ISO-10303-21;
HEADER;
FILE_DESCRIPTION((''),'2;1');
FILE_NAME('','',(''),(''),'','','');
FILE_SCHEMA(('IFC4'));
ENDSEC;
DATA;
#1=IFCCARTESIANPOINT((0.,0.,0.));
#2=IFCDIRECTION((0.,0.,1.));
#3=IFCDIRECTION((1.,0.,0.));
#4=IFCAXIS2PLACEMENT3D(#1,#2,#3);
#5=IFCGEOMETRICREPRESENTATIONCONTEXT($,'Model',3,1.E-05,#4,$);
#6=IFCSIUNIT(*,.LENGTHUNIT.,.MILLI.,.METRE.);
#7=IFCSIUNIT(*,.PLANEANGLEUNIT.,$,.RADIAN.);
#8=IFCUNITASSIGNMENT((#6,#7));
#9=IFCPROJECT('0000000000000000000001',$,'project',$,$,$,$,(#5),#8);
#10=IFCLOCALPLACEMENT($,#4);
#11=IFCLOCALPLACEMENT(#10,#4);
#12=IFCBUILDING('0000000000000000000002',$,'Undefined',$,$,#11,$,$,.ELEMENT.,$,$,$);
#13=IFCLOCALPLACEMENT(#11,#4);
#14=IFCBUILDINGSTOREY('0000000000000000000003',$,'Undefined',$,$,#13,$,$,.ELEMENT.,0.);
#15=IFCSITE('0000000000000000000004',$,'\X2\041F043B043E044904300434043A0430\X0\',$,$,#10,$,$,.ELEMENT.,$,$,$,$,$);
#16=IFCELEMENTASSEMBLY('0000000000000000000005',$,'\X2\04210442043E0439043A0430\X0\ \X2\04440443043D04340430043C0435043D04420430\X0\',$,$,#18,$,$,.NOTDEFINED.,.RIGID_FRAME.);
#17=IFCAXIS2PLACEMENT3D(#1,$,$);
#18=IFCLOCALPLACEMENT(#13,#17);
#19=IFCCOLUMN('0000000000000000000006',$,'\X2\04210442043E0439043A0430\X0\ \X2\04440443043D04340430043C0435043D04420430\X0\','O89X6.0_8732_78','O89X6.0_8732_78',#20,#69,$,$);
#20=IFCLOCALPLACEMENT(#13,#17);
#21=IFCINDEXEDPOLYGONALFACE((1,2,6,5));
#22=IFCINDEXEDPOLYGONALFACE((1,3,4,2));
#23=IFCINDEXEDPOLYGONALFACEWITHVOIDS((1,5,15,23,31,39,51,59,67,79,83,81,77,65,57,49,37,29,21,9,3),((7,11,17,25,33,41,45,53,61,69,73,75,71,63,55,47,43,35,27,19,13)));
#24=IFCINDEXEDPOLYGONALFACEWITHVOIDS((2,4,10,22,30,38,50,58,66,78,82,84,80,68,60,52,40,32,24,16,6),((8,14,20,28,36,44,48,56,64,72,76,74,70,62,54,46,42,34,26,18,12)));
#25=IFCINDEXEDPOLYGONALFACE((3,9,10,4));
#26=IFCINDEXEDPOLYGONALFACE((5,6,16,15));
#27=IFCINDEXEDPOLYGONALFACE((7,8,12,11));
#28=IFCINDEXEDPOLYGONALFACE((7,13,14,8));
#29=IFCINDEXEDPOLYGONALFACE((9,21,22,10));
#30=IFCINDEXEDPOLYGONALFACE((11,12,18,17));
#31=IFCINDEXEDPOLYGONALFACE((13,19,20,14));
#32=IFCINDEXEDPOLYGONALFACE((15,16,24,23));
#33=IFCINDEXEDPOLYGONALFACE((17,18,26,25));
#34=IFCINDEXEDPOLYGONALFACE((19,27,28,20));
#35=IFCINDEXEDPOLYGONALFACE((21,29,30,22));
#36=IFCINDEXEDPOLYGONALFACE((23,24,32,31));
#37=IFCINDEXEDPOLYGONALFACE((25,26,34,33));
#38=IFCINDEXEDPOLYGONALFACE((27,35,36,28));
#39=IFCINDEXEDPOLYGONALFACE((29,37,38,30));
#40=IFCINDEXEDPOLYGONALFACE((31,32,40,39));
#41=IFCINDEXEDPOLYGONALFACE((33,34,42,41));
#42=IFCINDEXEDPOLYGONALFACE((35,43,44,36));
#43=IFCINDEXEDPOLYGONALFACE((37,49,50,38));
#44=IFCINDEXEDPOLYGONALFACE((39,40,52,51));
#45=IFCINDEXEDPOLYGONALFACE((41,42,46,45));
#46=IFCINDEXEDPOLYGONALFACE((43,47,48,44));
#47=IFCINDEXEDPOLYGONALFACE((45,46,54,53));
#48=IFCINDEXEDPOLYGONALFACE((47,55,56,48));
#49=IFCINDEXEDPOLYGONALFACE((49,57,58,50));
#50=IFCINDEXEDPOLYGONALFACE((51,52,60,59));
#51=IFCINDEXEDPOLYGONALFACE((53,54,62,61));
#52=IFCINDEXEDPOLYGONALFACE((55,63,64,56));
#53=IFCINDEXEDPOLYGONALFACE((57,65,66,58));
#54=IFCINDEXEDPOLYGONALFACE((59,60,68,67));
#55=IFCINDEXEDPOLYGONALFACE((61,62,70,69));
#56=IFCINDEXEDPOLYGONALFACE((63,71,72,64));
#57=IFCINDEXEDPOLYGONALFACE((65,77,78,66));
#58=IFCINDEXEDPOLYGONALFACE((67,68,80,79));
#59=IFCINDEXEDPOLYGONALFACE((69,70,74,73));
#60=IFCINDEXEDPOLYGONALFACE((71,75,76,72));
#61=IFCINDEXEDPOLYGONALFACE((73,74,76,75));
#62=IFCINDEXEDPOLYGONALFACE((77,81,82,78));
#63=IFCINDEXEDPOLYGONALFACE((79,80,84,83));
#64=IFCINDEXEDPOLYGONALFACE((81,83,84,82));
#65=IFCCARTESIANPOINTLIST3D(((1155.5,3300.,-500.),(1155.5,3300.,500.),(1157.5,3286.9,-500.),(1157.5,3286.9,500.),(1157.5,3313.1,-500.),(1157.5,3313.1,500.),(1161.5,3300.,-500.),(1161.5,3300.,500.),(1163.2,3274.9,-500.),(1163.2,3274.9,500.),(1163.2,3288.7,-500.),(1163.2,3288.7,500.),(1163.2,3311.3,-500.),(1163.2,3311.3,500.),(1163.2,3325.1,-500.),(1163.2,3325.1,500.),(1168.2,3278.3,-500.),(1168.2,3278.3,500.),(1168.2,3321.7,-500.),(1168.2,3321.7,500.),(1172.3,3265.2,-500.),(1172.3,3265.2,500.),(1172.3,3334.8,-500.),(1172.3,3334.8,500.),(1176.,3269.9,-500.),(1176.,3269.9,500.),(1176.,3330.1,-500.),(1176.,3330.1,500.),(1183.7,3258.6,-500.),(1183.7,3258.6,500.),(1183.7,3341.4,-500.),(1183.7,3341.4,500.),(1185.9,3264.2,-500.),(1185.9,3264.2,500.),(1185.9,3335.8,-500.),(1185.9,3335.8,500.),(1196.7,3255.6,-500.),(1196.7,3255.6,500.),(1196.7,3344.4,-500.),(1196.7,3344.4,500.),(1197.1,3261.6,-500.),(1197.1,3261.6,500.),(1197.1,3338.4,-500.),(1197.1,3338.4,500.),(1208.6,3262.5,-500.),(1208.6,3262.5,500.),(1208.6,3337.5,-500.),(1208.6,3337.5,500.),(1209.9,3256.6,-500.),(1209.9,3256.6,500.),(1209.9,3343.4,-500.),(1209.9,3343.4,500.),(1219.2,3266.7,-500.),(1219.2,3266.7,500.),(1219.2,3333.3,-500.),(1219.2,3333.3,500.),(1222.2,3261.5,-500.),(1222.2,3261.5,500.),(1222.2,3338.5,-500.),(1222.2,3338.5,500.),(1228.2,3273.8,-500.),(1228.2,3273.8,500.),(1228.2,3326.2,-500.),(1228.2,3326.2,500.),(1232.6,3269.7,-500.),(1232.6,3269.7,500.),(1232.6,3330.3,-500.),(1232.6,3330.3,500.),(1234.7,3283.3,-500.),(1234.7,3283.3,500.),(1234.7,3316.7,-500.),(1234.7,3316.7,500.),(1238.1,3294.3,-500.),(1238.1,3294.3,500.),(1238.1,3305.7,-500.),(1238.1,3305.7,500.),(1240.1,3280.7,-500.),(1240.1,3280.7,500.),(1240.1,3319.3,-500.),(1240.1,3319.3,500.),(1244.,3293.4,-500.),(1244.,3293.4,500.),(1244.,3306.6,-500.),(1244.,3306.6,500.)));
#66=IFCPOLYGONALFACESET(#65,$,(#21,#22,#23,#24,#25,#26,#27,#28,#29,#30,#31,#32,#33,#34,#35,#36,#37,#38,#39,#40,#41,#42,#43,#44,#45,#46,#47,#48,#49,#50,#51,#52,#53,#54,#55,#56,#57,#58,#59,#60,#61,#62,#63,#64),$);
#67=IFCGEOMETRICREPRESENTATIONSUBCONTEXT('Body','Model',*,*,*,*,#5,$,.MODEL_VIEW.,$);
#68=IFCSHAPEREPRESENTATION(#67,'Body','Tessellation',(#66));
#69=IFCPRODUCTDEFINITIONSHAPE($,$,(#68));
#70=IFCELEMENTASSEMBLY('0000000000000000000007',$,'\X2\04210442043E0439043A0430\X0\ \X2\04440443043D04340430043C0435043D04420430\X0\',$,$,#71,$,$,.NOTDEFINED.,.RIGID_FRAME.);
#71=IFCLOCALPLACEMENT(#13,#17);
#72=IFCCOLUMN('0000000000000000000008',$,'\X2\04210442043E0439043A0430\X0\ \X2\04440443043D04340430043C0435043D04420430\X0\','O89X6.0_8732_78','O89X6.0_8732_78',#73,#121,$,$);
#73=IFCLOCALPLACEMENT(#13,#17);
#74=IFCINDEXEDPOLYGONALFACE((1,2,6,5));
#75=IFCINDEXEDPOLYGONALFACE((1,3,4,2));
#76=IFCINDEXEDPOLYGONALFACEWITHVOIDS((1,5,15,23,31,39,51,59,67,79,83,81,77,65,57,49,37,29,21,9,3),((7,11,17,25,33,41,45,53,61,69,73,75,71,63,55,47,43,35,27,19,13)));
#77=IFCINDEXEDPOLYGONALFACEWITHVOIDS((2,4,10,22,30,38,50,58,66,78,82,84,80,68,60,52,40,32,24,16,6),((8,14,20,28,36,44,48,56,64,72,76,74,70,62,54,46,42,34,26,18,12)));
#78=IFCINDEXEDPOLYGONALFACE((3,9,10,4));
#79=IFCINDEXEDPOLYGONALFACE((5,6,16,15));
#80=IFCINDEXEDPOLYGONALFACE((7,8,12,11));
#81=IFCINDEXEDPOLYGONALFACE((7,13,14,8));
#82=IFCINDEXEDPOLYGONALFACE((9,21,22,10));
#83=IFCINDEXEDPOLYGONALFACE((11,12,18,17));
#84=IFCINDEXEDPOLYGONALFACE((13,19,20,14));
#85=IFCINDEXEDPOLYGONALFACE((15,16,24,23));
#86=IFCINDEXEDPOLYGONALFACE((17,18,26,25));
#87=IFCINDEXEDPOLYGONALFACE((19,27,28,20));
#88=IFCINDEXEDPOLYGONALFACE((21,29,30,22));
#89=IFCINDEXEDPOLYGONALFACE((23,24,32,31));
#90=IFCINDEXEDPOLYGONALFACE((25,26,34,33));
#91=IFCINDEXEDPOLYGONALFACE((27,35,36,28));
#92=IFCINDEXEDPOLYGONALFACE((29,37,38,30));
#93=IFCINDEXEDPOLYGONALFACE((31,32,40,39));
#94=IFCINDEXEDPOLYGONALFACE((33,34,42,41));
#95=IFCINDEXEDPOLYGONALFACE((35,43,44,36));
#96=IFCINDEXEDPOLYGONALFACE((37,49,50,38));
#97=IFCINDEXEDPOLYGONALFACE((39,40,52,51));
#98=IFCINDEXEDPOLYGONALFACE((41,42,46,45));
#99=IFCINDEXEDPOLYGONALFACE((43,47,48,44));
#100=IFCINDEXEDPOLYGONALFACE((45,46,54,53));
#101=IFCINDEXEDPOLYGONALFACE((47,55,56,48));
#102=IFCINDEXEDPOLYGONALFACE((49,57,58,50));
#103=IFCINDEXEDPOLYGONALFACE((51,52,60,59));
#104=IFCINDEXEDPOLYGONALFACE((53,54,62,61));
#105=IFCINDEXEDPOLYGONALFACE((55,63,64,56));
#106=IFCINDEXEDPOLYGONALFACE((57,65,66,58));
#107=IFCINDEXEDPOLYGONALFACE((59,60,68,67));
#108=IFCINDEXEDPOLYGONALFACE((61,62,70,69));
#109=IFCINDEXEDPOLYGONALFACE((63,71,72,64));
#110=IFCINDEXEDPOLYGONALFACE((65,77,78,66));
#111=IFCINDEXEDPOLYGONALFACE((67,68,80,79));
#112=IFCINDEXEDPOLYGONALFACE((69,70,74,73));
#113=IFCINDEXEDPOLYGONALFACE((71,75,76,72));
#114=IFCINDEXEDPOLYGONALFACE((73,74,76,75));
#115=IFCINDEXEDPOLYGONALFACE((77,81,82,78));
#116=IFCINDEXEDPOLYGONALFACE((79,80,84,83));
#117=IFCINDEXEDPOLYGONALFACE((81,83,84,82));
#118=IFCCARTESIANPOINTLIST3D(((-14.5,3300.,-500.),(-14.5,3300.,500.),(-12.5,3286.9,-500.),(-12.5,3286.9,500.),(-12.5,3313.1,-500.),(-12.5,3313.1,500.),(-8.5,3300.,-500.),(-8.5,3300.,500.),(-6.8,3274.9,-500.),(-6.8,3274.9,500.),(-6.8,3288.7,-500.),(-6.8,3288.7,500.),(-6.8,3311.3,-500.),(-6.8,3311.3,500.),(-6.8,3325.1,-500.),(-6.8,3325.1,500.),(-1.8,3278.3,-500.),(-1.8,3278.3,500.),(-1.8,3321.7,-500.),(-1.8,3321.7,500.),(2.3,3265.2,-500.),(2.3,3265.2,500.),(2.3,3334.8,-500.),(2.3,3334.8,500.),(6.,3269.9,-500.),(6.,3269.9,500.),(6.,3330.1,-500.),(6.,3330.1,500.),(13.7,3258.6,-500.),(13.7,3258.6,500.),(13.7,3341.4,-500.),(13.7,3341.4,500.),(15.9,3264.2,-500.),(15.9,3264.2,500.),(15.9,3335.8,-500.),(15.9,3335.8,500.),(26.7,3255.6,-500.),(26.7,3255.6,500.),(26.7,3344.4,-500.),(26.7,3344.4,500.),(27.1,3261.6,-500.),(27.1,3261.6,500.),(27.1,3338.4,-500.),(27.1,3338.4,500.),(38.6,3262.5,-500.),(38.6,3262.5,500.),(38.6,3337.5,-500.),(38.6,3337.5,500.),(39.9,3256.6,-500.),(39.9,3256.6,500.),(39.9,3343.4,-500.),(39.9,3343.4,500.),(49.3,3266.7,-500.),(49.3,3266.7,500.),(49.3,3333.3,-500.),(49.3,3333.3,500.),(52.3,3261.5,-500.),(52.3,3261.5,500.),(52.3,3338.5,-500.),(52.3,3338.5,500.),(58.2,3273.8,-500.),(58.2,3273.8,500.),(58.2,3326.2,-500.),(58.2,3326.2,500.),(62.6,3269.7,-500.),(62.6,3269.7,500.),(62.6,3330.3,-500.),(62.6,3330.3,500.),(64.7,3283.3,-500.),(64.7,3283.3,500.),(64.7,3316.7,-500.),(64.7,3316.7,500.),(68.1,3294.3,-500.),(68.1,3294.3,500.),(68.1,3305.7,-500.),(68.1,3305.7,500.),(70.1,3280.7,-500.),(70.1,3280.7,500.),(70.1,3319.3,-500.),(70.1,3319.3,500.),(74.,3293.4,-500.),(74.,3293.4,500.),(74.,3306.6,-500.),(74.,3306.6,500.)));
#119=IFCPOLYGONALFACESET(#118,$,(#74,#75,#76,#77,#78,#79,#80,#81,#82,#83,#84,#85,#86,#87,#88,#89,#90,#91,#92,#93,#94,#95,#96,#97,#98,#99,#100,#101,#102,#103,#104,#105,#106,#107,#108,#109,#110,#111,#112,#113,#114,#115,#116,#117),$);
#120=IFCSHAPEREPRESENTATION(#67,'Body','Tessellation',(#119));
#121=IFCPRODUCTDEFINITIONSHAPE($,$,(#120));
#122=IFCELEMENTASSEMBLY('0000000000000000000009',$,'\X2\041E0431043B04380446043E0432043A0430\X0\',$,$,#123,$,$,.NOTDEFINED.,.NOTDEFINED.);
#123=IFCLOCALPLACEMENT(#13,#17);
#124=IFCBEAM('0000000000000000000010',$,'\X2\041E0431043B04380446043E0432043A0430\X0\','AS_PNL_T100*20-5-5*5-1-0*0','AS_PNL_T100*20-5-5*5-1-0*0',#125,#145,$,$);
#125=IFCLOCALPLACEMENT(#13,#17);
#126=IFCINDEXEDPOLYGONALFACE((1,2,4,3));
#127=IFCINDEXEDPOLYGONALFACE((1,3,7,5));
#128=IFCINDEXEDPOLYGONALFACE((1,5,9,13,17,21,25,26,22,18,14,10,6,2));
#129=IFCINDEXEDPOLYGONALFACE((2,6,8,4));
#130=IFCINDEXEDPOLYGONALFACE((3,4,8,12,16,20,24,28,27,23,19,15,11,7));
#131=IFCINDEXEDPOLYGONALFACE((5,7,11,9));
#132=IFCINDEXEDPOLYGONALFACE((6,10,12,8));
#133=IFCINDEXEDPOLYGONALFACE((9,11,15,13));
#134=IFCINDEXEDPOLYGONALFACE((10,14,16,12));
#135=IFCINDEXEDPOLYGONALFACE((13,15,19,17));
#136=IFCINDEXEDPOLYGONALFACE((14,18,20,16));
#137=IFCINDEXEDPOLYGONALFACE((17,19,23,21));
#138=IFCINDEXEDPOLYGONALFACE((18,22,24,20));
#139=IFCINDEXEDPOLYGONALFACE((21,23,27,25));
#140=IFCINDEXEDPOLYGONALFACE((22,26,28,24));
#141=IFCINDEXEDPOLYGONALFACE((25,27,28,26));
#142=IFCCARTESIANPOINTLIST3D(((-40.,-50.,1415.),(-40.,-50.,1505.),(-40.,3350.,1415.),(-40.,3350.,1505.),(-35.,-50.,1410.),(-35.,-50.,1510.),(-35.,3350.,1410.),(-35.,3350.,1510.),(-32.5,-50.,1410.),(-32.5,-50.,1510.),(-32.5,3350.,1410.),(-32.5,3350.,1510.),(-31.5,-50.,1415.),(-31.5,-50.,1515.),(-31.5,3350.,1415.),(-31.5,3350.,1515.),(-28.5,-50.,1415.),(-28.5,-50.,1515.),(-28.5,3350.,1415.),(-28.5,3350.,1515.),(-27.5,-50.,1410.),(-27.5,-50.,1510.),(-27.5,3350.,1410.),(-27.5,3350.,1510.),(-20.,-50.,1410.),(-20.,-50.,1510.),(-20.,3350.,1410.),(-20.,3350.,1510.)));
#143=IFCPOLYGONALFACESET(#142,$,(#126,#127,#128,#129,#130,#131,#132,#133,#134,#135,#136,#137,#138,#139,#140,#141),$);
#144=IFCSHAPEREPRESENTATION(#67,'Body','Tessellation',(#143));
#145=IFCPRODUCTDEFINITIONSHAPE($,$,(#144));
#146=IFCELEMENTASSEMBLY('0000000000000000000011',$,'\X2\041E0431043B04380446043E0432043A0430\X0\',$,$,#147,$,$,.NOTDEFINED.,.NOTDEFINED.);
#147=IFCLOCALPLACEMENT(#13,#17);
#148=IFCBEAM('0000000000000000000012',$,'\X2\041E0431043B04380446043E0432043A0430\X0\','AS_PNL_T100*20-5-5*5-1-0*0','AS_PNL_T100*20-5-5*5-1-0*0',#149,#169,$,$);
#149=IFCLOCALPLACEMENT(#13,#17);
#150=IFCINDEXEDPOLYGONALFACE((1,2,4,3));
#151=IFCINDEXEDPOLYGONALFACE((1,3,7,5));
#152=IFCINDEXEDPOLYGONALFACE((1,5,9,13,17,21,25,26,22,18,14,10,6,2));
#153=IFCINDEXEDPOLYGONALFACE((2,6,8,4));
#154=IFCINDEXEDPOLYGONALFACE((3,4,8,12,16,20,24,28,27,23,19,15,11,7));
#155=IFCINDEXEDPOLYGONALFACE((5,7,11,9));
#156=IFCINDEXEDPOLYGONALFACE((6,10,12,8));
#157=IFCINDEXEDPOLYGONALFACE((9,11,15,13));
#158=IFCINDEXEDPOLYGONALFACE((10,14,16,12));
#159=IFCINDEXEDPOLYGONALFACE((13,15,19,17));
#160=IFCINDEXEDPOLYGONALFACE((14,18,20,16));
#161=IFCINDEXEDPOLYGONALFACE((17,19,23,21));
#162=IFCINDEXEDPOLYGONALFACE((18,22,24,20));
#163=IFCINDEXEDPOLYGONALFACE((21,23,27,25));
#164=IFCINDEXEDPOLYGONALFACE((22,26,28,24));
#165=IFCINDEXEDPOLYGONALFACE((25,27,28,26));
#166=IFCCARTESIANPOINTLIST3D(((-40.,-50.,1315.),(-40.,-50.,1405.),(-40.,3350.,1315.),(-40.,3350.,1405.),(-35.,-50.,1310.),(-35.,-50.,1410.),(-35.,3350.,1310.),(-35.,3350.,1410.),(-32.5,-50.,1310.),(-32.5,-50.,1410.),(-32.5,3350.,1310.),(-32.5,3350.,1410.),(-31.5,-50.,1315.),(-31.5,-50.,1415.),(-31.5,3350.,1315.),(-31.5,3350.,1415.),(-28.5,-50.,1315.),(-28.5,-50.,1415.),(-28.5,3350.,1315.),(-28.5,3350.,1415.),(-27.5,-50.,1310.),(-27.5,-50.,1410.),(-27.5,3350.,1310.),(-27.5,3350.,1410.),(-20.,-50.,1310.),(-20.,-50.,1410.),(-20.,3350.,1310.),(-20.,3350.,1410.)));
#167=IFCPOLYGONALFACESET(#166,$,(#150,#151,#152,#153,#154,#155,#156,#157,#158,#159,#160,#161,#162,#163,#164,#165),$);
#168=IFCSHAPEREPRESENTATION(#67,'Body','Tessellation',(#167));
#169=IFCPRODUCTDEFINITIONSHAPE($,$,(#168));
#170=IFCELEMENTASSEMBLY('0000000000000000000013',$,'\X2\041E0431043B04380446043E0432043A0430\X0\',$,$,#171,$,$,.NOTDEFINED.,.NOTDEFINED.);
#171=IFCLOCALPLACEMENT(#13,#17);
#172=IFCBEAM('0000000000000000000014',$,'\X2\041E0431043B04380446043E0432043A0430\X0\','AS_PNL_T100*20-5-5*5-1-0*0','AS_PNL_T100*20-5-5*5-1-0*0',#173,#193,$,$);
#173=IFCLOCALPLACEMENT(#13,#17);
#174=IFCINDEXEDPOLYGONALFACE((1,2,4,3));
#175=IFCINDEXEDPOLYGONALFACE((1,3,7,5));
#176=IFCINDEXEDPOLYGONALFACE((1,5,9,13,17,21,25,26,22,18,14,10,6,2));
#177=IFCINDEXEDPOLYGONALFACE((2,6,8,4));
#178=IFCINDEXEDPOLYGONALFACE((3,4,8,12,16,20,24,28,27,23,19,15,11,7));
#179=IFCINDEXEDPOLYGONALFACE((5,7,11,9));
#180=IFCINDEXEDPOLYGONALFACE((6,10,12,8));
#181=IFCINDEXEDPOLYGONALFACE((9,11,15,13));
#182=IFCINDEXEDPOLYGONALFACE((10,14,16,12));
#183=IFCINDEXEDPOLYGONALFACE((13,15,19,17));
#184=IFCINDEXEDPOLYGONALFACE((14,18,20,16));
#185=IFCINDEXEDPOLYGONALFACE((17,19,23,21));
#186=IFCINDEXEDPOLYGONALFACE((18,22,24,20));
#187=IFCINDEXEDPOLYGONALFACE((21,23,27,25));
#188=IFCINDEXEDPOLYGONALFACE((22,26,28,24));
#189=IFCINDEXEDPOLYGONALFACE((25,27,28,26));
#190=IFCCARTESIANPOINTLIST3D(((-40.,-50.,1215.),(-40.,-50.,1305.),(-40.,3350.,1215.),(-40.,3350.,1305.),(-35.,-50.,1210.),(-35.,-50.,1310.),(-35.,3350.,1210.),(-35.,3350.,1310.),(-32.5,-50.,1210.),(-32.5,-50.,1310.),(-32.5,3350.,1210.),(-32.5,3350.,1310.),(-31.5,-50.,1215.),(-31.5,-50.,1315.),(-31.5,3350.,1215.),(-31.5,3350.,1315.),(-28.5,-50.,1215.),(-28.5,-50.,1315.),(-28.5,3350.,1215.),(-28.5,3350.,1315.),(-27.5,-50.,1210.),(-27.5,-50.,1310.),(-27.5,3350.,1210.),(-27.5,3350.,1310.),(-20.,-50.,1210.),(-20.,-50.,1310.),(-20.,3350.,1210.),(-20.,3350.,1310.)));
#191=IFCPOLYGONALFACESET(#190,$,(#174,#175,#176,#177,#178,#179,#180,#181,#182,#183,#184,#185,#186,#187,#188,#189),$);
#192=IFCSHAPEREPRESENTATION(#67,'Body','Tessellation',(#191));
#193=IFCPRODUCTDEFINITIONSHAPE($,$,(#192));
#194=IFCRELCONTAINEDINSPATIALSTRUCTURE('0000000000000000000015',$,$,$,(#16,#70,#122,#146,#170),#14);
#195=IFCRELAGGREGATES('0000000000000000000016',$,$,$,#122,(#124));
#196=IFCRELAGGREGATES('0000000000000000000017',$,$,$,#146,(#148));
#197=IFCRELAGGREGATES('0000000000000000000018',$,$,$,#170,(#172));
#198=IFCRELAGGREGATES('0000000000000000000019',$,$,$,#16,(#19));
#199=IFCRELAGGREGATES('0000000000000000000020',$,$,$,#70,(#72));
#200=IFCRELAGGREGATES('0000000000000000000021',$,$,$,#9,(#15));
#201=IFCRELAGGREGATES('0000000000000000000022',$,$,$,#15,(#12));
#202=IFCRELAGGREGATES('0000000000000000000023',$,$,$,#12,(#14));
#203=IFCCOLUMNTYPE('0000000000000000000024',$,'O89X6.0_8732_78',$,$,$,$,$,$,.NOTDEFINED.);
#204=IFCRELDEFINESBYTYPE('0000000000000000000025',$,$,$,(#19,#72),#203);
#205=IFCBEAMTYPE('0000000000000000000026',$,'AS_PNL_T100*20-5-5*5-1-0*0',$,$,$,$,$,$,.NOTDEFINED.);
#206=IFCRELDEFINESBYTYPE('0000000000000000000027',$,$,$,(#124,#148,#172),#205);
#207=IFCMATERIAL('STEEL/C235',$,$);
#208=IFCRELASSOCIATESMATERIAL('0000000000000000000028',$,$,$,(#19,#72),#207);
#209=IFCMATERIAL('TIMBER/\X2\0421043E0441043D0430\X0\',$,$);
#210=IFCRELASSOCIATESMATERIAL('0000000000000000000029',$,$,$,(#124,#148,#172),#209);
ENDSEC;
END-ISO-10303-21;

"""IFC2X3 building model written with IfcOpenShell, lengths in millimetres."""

from ifc_helpers import new_model, si_unit, frame, origin_with_axes, origin_2d_with_axis, place, context, subcontext, project, spatial, polyline, hollow_circle, outline, extrude, material, type_object, element, aggregate, save


model = new_model("IFC2X3")

# Units and contexts
model_context = context("Model", 3, precision=1e-05, world=origin_with_axes())
body_context = subcontext(model_context, "Body", "Model", "MODEL_VIEW")
ifc_project = project(units=[si_unit("LENGTHUNIT", "METRE", prefix="MILLI"), si_unit("PLANEANGLEUNIT", "RADIAN")], contexts=[model_context])

# Site, building, storey
site_placement = place(None, origin_with_axes())
site = spatial("IfcSite", under=ifc_project, at=site_placement, Name="Площадка", CompositionType="ELEMENT")
building_placement = place(site_placement, origin_with_axes())
building = spatial("IfcBuilding", under=site, at=building_placement, Name="Undefined", CompositionType="ELEMENT")
storey_placement = place(building_placement, origin_with_axes())
storey = spatial("IfcBuildingStorey", under=building, at=storey_placement, Name="Undefined", CompositionType="ELEMENT", Elevation=0.0)

# Element assemblies, columns
assembly_1_placement = place(storey_placement, origin_with_axes())
assembly_1 = element("IfcElementAssembly", 1, at=assembly_1_placement, inside=storey, Name="Стойка фундамента", AssemblyPlace="NOTDEFINED", PredefinedType="RIGID_FRAME")
ifc_material_1 = material(Name="STEEL/C235")
column_type = type_object("IfcColumnType", Name="O89X6.0_8732_78", PredefinedType="NOTDEFINED")
column_1_placement = place(assembly_1_placement, frame((1200.0, 3300.0, -500.0), z_axis=(0.0, 0.0, 1.0), x_axis=(0.0, 1.0, 0.0)))
column_1 = element("IfcColumn", 2, at=column_1_placement, type_object=column_type, material=ifc_material_1, Name="Стойка фундамента", Description="O89X6.0_8732_78", ObjectType="O89X6.0_8732_78", context=body_context, shape_type="SweptSolid", body=[
    extrude(hollow_circle(Radius=44.5, WallThickness=6.0, at=origin_2d_with_axis()), frame((0.0, 0.0, 1000.0), z_axis=(0.0, 0.0, -1.0), x_axis=(0.0, 1.0, 0.0)), (0.0, 0.0, 1.0), 1000.0),
])
assembly_2_placement = place(storey_placement, origin_with_axes())
assembly_2 = element("IfcElementAssembly", 3, at=assembly_2_placement, inside=storey, Name="Стойка фундамента", AssemblyPlace="NOTDEFINED", PredefinedType="RIGID_FRAME")
column_2_placement = place(assembly_2_placement, frame((30.0, 3300.0, -500.0), z_axis=(0.0, 0.0, 1.0), x_axis=(0.0, 1.0, 0.0)))
column_2 = element("IfcColumn", 4, at=column_2_placement, type_object=column_type, material=ifc_material_1, Name="Стойка фундамента", Description="O89X6.0_8732_78", ObjectType="O89X6.0_8732_78", context=body_context, shape_type="SweptSolid", body=[
    extrude(hollow_circle(Radius=44.5, WallThickness=6.0, at=origin_2d_with_axis()), frame((0.0, 0.0, 1000.0), z_axis=(0.0, 0.0, -1.0), x_axis=(0.0, 1.0, 0.0)), (0.0, 0.0, 1.0), 1000.0),
])

# Element assemblies, beams
assembly_3_placement = place(storey_placement, origin_with_axes())
assembly_3 = element("IfcElementAssembly", 5, at=assembly_3_placement, inside=storey, Name="Облицовка", AssemblyPlace="NOTDEFINED", PredefinedType="NOTDEFINED")
ifc_material_2 = material(Name="TIMBER/Сосна")
beam_type = type_object("IfcBeamType", Name="AS_PNL_T100*20-5-5*5-1-0*0", PredefinedType="NOTDEFINED")
beam_1_placement = place(assembly_3_placement, frame((-30.0, 3350.0, 1460.0), z_axis=(0.0, 0.0, 1.0), x_axis=(0.0, -1.0, 0.0)))
beam_1 = element("IfcBeam", 6, at=beam_1_placement, type_object=beam_type, material=ifc_material_2, Name="Облицовка", Description="AS_PNL_T100*20-5-5*5-1-0*0", ObjectType="AS_PNL_T100*20-5-5*5-1-0*0", context=body_context, shape_type="SweptSolid", body=[
    extrude(outline(polyline([(-2.5, -50.0), (-10.0, -50.0), (-10.0, 50.0), (-2.5, 50.0), (-1.5, 55.0), (1.5, 55.0), (2.5, 50.0), (5.0, 50.0), (10.0, 45.0), (10.0, -45.0), (5.0, -50.0), (2.5, -50.0), (1.5, -45.0), (-1.5, -45.0), (-2.5, -50.0)])), frame((3400.0, 0.0, 0.0), z_axis=(-1.0, 0.0, 0.0), x_axis=(0.0, -1.0, 0.0)), (0.0, 0.0, 1.0), 3400.0),
])
aggregate(assembly_3, [beam_1])
assembly_4_placement = place(storey_placement, origin_with_axes())
assembly_4 = element("IfcElementAssembly", 7, at=assembly_4_placement, inside=storey, Name="Облицовка", AssemblyPlace="NOTDEFINED", PredefinedType="NOTDEFINED")
beam_2_placement = place(assembly_4_placement, frame((-30.0, 3350.0, 1360.0), z_axis=(0.0, 0.0, 1.0), x_axis=(0.0, -1.0, 0.0)))
beam_2 = element("IfcBeam", 8, at=beam_2_placement, type_object=beam_type, material=ifc_material_2, Name="Облицовка", Description="AS_PNL_T100*20-5-5*5-1-0*0", ObjectType="AS_PNL_T100*20-5-5*5-1-0*0", context=body_context, shape_type="SweptSolid", body=[
    extrude(outline(polyline([(-2.5, -50.0), (-10.0, -50.0), (-10.0, 50.0), (-2.5, 50.0), (-1.5, 55.0), (1.5, 55.0), (2.5, 50.0), (5.0, 50.0), (10.0, 45.0), (10.0, -45.0), (5.0, -50.0), (2.5, -50.0), (1.5, -45.0), (-1.5, -45.0), (-2.5, -50.0)])), frame((3400.0, 0.0, 0.0), z_axis=(-1.0, 0.0, 0.0), x_axis=(0.0, -1.0, 0.0)), (0.0, 0.0, 1.0), 3400.0),
])
aggregate(assembly_4, [beam_2])
assembly_5_placement = place(storey_placement, origin_with_axes())
assembly_5 = element("IfcElementAssembly", 9, at=assembly_5_placement, inside=storey, Name="Облицовка", AssemblyPlace="NOTDEFINED", PredefinedType="NOTDEFINED")
beam_3_placement = place(assembly_5_placement, frame((-30.0, 3350.0, 1260.0), z_axis=(0.0, 0.0, 1.0), x_axis=(0.0, -1.0, 0.0)))
beam_3 = element("IfcBeam", 10, at=beam_3_placement, type_object=beam_type, material=ifc_material_2, Name="Облицовка", Description="AS_PNL_T100*20-5-5*5-1-0*0", ObjectType="AS_PNL_T100*20-5-5*5-1-0*0", context=body_context, shape_type="SweptSolid", body=[
    extrude(outline(polyline([(-2.5, -50.0), (-10.0, -50.0), (-10.0, 50.0), (-2.5, 50.0), (-1.5, 55.0), (1.5, 55.0), (2.5, 50.0), (5.0, 50.0), (10.0, 45.0), (10.0, -45.0), (5.0, -50.0), (2.5, -50.0), (1.5, -45.0), (-1.5, -45.0), (-2.5, -50.0)])), frame((3400.0, 0.0, 0.0), z_axis=(-1.0, 0.0, 0.0), x_axis=(0.0, -1.0, 0.0)), (0.0, 0.0, 1.0), 3400.0),
])
aggregate(assembly_5, [beam_3])

aggregate(assembly_1, [column_1])
aggregate(assembly_2, [column_2])

save(model, "model.ifc")
